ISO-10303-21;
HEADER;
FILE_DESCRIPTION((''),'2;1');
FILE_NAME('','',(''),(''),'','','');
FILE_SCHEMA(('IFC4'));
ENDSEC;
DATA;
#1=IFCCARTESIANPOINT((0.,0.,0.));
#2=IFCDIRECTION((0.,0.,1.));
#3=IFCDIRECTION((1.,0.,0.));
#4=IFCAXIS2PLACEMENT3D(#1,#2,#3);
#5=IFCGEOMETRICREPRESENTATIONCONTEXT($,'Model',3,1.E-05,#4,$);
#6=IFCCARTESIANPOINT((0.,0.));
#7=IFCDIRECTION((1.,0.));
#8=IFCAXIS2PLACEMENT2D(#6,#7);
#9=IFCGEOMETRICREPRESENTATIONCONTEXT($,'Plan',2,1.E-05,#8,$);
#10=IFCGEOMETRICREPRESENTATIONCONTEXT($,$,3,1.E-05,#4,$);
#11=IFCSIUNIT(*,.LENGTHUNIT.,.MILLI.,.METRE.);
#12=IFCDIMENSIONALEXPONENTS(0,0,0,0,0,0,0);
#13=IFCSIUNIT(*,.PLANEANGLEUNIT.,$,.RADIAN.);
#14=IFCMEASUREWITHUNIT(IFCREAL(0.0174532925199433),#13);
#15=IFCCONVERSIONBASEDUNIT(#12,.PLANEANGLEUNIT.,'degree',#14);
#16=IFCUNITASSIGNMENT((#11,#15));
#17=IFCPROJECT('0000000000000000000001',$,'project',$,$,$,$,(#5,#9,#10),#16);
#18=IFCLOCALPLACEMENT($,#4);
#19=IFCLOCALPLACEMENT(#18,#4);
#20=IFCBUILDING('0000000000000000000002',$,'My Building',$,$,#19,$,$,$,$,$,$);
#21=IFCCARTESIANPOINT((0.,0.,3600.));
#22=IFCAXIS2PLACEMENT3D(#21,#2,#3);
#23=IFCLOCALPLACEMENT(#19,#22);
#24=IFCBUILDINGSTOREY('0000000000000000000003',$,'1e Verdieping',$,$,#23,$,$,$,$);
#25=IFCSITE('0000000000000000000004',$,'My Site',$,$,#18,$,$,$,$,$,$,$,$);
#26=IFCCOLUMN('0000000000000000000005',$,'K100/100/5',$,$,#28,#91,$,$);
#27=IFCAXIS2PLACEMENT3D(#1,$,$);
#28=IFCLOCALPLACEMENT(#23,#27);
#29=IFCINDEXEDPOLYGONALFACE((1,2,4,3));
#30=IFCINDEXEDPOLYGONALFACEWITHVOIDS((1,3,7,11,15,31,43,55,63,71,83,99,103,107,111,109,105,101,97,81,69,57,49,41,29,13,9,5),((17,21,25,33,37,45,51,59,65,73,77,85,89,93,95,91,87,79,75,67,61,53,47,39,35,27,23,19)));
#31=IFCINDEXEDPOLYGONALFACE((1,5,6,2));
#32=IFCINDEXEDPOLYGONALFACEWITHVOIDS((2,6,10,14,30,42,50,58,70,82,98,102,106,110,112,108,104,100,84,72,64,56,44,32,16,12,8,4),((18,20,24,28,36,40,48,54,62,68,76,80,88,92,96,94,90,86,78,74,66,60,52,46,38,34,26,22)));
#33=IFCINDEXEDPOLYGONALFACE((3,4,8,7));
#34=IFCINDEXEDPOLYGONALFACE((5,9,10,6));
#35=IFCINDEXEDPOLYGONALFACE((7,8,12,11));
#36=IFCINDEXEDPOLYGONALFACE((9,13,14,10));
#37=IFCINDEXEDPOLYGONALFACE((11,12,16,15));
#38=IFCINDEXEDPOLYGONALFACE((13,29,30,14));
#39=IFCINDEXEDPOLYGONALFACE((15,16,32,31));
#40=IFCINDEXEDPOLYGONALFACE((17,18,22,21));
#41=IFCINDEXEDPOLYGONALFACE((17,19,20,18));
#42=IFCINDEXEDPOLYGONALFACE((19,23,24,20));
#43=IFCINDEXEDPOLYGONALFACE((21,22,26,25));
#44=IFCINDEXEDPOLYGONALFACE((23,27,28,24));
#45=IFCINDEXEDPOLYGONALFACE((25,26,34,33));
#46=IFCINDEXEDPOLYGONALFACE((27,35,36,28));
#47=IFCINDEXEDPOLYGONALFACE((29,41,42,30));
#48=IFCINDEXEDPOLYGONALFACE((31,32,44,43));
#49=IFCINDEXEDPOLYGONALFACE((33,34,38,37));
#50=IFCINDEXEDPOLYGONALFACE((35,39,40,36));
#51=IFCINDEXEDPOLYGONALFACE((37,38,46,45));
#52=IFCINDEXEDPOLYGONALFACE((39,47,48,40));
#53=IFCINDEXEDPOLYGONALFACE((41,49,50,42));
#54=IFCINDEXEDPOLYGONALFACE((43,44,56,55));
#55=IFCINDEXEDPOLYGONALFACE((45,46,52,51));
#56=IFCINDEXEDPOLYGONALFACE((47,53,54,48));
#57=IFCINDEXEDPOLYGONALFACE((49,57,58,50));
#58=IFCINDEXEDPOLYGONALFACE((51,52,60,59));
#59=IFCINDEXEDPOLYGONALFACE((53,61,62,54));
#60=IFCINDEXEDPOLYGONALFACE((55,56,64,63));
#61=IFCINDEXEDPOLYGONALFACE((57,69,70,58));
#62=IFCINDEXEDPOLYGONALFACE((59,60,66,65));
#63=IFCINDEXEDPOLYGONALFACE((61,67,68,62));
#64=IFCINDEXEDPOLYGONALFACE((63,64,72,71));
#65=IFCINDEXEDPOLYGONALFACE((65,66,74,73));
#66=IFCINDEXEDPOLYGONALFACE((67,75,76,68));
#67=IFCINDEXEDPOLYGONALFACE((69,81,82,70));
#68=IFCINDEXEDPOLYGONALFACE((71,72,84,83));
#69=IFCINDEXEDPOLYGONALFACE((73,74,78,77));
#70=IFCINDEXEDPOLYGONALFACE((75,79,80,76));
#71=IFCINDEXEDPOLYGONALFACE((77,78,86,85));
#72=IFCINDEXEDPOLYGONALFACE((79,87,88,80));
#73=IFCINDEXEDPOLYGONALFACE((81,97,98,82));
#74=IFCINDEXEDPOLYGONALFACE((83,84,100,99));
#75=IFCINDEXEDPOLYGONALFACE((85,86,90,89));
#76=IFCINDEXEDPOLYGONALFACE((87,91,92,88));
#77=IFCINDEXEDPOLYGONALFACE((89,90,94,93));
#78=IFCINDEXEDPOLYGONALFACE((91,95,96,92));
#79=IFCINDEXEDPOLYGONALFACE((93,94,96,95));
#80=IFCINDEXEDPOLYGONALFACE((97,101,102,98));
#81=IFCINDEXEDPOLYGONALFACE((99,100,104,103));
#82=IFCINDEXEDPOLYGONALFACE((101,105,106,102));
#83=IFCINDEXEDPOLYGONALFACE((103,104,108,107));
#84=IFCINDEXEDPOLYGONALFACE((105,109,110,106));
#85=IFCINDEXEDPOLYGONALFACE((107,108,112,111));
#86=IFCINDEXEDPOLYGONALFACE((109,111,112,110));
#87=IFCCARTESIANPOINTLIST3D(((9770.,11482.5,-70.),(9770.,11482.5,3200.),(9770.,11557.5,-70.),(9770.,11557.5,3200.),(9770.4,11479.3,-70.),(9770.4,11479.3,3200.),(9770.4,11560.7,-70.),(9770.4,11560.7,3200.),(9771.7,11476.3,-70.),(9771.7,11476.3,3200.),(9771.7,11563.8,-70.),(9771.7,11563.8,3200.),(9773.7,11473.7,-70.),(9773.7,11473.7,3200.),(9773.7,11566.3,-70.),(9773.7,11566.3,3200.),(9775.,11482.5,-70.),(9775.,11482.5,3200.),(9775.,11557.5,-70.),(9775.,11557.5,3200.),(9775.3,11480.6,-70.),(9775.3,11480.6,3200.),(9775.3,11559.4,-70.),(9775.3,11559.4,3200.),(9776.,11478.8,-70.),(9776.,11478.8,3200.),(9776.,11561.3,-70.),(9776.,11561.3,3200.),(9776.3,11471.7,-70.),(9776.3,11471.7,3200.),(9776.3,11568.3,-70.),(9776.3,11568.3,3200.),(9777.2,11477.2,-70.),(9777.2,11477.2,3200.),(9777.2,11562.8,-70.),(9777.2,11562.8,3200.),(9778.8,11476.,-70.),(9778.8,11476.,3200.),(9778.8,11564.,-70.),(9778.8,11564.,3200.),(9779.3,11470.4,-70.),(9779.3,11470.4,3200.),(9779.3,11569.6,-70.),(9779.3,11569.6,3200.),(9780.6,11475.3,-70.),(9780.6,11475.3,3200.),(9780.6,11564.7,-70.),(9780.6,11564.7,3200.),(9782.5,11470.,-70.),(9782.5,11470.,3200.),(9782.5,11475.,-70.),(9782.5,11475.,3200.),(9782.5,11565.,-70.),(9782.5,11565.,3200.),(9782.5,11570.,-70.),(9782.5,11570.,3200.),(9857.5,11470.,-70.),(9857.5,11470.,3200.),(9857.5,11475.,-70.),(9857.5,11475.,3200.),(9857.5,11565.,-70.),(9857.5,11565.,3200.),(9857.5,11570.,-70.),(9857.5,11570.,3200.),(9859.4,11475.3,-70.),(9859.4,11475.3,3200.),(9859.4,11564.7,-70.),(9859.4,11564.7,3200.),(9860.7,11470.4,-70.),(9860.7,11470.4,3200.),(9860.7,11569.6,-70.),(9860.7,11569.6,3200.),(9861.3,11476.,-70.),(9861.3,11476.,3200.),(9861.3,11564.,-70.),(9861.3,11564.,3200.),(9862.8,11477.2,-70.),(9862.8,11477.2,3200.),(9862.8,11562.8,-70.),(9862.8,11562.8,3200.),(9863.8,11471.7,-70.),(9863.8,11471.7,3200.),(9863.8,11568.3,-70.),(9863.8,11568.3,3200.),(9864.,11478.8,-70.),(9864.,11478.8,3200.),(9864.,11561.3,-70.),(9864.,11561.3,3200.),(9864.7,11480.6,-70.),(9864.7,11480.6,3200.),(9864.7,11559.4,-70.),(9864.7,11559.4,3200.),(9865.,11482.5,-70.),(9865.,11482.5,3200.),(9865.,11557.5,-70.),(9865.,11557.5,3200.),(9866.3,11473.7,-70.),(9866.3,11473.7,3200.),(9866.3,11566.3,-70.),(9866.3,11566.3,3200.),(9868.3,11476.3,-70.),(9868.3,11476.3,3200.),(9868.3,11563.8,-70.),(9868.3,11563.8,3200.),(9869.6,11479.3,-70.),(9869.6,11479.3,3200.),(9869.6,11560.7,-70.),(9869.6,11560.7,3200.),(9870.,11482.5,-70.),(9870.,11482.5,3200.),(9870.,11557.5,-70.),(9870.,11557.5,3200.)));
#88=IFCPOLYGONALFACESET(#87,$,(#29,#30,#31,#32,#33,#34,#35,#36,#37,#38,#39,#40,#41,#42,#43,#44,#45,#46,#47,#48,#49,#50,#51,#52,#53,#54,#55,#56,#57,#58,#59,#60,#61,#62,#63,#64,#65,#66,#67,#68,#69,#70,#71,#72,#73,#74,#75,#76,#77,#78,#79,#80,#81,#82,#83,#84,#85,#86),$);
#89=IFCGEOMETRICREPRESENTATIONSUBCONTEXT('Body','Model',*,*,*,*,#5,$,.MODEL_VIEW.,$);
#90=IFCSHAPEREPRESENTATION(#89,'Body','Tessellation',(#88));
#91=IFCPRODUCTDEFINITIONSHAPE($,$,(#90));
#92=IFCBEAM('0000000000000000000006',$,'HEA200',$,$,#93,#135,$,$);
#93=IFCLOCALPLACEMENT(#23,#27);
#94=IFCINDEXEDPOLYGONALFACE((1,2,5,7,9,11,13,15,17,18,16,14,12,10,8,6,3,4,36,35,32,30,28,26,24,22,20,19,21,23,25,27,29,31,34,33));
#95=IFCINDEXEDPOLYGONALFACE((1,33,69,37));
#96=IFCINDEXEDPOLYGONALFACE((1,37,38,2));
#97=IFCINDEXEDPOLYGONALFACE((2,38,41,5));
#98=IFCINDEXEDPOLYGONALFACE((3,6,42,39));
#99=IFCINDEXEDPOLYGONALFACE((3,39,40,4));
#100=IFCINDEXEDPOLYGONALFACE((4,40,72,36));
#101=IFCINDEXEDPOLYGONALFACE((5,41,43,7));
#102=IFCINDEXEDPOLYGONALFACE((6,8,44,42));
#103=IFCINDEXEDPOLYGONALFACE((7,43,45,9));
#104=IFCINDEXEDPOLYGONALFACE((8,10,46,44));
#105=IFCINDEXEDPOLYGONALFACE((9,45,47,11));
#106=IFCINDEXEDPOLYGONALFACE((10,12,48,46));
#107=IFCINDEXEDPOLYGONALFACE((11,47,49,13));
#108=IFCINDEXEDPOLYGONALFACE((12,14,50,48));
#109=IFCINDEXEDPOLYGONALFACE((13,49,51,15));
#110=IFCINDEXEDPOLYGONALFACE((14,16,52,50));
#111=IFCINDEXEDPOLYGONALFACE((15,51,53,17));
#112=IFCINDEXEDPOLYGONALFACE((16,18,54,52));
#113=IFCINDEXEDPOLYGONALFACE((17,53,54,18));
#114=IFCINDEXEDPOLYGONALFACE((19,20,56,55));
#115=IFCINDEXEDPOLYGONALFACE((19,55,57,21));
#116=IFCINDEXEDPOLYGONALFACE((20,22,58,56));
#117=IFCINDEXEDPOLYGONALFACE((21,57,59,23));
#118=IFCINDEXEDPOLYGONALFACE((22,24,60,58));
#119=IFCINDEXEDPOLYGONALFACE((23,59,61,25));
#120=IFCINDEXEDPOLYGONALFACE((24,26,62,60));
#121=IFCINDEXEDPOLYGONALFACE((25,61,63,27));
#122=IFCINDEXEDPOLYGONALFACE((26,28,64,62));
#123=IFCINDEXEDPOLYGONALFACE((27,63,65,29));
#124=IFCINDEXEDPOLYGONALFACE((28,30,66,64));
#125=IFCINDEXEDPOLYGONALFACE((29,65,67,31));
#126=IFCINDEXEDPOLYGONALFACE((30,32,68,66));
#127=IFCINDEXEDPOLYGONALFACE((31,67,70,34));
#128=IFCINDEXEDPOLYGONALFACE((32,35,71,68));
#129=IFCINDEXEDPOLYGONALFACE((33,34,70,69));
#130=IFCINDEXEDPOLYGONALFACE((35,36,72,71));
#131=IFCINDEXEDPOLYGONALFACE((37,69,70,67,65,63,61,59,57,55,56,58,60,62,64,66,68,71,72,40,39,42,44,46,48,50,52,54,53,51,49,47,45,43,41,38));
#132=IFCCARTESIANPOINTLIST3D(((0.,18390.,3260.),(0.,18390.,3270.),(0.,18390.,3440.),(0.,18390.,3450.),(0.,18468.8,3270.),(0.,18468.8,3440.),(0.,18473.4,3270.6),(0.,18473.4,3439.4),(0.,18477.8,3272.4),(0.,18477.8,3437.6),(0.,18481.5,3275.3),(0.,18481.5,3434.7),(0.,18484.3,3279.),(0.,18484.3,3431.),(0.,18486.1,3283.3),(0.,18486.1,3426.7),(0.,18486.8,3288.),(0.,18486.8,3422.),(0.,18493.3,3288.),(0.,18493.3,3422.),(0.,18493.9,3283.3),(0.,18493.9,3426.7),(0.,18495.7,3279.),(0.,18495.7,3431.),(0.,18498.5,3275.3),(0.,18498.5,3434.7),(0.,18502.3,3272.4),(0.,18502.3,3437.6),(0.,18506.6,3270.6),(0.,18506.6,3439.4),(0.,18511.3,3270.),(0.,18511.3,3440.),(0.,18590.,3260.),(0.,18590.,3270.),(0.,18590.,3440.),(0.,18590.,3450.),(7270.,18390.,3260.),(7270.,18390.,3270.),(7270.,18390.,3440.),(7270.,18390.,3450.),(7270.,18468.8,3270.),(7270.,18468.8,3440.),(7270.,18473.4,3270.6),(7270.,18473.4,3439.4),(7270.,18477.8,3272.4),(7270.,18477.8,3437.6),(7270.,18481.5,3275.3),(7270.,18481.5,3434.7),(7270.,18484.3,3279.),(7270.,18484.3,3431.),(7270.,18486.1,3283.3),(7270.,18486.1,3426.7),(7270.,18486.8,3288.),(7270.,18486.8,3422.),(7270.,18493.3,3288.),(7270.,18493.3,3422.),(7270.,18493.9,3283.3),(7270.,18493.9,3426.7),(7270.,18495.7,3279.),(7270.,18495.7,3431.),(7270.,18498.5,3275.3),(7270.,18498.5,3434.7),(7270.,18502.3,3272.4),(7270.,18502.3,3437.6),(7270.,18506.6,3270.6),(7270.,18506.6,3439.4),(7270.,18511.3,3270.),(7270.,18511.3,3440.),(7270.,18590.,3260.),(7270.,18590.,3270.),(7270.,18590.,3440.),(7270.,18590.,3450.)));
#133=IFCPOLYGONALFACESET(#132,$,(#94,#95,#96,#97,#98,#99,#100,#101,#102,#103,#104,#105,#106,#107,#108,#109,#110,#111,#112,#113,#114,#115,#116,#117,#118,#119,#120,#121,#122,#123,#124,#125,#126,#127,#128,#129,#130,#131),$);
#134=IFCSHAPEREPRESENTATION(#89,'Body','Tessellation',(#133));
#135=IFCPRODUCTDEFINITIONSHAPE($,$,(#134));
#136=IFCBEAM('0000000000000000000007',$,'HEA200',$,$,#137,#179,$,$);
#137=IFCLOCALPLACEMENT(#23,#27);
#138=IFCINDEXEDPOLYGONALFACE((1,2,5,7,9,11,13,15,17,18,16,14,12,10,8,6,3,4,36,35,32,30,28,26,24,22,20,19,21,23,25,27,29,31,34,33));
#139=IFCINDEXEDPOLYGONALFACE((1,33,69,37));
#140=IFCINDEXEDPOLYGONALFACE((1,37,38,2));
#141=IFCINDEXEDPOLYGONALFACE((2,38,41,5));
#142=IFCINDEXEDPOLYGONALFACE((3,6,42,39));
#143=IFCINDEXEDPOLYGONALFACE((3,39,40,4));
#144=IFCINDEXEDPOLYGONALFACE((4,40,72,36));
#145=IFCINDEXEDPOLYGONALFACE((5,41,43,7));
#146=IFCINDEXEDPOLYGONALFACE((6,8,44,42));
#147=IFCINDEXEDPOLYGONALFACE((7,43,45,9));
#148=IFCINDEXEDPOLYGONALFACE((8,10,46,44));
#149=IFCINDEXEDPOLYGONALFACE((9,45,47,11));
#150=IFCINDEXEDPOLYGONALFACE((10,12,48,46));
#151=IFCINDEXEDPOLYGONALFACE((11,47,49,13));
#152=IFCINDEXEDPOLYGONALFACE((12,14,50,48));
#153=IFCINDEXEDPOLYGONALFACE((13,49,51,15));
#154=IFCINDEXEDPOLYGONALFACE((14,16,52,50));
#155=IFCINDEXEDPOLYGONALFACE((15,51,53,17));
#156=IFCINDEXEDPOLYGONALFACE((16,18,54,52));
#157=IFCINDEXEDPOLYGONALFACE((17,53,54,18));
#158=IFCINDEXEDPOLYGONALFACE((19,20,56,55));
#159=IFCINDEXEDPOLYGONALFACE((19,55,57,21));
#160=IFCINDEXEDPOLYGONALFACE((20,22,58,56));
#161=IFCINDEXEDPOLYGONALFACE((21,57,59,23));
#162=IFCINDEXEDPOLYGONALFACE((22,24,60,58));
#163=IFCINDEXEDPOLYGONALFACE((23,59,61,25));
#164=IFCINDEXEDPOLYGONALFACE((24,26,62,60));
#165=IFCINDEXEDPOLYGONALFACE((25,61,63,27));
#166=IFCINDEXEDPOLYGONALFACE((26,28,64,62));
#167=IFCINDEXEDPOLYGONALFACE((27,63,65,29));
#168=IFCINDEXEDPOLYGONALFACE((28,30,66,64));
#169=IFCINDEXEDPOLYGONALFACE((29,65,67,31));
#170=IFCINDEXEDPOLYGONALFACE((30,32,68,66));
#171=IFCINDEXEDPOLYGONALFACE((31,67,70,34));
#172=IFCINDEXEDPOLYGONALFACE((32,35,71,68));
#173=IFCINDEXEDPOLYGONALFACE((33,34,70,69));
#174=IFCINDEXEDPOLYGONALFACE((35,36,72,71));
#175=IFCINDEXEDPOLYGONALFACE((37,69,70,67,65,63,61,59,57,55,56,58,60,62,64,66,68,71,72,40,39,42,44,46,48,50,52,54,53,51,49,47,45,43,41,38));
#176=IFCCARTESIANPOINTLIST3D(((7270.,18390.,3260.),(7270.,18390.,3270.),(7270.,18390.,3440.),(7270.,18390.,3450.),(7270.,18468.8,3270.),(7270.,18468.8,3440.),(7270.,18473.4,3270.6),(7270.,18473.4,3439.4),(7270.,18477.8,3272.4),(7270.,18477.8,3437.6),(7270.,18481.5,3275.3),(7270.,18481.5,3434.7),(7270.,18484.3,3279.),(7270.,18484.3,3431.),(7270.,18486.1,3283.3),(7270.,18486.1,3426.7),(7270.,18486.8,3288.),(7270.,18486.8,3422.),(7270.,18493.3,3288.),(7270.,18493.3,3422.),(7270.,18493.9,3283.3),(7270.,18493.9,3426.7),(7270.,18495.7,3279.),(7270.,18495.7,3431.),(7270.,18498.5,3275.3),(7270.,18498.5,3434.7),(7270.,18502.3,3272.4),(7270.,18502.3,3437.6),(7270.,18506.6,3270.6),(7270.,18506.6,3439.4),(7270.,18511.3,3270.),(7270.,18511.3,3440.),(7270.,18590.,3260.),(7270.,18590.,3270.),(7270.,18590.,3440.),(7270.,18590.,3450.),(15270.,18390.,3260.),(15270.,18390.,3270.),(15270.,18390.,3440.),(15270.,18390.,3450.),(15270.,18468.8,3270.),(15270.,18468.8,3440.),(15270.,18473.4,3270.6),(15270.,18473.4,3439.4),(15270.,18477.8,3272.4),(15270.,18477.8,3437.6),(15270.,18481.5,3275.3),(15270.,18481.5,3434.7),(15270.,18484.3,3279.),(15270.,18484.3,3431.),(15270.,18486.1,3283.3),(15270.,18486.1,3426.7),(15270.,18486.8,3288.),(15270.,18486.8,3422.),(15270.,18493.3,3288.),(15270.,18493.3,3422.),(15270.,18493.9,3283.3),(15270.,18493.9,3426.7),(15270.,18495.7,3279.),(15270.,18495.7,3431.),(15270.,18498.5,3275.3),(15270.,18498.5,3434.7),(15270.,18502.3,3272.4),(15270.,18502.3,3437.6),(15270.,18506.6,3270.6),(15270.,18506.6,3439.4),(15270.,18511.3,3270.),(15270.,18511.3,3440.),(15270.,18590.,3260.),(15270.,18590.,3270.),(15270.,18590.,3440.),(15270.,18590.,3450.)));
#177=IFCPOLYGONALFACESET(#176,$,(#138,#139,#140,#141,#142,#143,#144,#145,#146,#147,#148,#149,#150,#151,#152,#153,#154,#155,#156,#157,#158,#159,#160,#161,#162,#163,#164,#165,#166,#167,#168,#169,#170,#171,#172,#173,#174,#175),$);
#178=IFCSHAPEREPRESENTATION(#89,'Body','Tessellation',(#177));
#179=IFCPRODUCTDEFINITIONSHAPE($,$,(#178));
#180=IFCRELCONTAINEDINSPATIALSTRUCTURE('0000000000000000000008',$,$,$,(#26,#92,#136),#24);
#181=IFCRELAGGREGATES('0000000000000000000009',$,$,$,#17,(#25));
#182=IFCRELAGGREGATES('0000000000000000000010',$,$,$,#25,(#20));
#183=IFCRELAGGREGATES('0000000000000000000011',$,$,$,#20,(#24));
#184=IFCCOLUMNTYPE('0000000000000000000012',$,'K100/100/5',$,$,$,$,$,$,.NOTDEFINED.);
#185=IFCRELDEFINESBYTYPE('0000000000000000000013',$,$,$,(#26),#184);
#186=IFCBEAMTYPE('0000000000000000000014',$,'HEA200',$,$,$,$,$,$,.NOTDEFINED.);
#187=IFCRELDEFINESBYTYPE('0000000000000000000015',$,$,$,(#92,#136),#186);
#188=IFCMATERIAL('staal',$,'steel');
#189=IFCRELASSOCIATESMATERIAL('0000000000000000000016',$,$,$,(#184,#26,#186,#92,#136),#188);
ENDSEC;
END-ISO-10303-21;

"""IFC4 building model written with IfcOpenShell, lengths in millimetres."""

from ifc_helpers import new_model, entity, si_unit, converted_unit, frame, origin_with_axes, origin_2d_with_axis, place, context, subcontext, project, spatial, hollow_rectangle, i_section, extrude, material, material_profile, profile_set, profile_usage, type_object, element, save


model = new_model("IFC4")

# Units and contexts
model_context = context("Model", 3, precision=1e-05, world=origin_with_axes())
plan_context = context("Plan", 2, precision=1e-05, world=origin_2d_with_axis())
context_of_model = context(None, 3, precision=1e-05, world=origin_with_axes())
body_context = subcontext(model_context, "Body", "Model", "MODEL_VIEW")
ifc_project = project(units=[si_unit("LENGTHUNIT", "METRE", prefix="MILLI"), converted_unit("PLANEANGLEUNIT", "degree", entity("IfcReal", 0.0174532925199433), si_unit("PLANEANGLEUNIT", "RADIAN"), dimensions=[0, 0, 0, 0, 0, 0, 0])], contexts=[model_context, plan_context, context_of_model])

# Site, building, storey
site_placement = place(None, origin_with_axes())
site = spatial("IfcSite", under=ifc_project, at=site_placement, Name="My Site")
building_placement = place(site_placement, origin_with_axes())
building = spatial("IfcBuilding", under=site, at=building_placement, Name="My Building")
storey_placement = place(building_placement, frame((0.0, 0.0, 3600.0), z_axis=(0.0, 0.0, 1.0), x_axis=(1.0, 0.0, 0.0)))
storey = spatial("IfcBuildingStorey", under=building, at=storey_placement, Name="1e Verdieping")

# Column
ifc_material_1 = material(Name="staal", Category="steel")
ifc_material_profile_1 = material_profile(ifc_material_1, hollow_rectangle(XDim=100.0, YDim=100.0, WallThickness=5.0, InnerFilletRadius=7.5, OuterFilletRadius=12.5))
ifc_profile_set_1 = profile_set([ifc_material_profile_1], Name="K100/100/5")
column_type_1 = type_object("IfcColumnType", Name="K100/100/5", PredefinedType="NOTDEFINED", material=ifc_profile_set_1)
ifc_profile_usage_1 = profile_usage(ifc_profile_set_1, cardinal=5)
column_1_placement = place(storey_placement, frame((9820.0, 11520.0, -70.0), z_axis=(0.0, 0.0, 1.0), x_axis=(1.0, 0.0, 0.0)))
element("IfcColumn", 1, at=column_1_placement, inside=storey, type_object=column_type_1, material=ifc_profile_usage_1, Name="K100/100/5", context=body_context, shape_type="SweptSolid", body=[
    extrude(hollow_rectangle(XDim=100.0, YDim=100.0, WallThickness=5.0, InnerFilletRadius=7.5, OuterFilletRadius=12.5), origin_with_axes(), (0.0, 0.0, 1.0), 3270.0),
])

# Beams
ifc_material_profile_2 = material_profile(ifc_material_1, i_section(OverallWidth=200.0, OverallDepth=190.0, WebThickness=6.5, FlangeThickness=10.0, FilletRadius=18.0))
ifc_profile_set_2 = profile_set([ifc_material_profile_2], Name="HEA200")
ifc_profile_usage_2 = profile_usage(ifc_profile_set_2, cardinal=5)
beam_type_1 = type_object("IfcBeamType", Name="HEA200", PredefinedType="NOTDEFINED", material=ifc_profile_set_2)
beam_1_placement = place(storey_placement, frame((0.0, 18490.0, 3355.0), z_axis=(1.0, 0.0, 0.0), x_axis=(0.0, 1.0, 0.0)))
element("IfcBeam", 2, at=beam_1_placement, inside=storey, type_object=beam_type_1, material=ifc_profile_usage_2, Name="HEA200", context=body_context, shape_type="SweptSolid", body=[
    extrude(i_section(OverallWidth=200.0, OverallDepth=190.0, WebThickness=6.5, FlangeThickness=10.0, FilletRadius=18.0), origin_with_axes(), (0.0, 0.0, 1.0), 7270.0),
])
ifc_profile_usage_3 = profile_usage(ifc_profile_set_2, cardinal=5)
beam_2_placement = place(storey_placement, frame((7270.0, 18490.0, 3355.0), z_axis=(1.0, 0.0, 0.0), x_axis=(0.0, 1.0, 0.0)))
element("IfcBeam", 3, at=beam_2_placement, inside=storey, type_object=beam_type_1, material=ifc_profile_usage_3, Name="HEA200", context=body_context, shape_type="SweptSolid", body=[
    extrude(i_section(OverallWidth=200.0, OverallDepth=190.0, WebThickness=6.5, FlangeThickness=10.0, FilletRadius=18.0), origin_with_axes(), (0.0, 0.0, 1.0), 8000.0),
])

save(model, "model.ifc")
